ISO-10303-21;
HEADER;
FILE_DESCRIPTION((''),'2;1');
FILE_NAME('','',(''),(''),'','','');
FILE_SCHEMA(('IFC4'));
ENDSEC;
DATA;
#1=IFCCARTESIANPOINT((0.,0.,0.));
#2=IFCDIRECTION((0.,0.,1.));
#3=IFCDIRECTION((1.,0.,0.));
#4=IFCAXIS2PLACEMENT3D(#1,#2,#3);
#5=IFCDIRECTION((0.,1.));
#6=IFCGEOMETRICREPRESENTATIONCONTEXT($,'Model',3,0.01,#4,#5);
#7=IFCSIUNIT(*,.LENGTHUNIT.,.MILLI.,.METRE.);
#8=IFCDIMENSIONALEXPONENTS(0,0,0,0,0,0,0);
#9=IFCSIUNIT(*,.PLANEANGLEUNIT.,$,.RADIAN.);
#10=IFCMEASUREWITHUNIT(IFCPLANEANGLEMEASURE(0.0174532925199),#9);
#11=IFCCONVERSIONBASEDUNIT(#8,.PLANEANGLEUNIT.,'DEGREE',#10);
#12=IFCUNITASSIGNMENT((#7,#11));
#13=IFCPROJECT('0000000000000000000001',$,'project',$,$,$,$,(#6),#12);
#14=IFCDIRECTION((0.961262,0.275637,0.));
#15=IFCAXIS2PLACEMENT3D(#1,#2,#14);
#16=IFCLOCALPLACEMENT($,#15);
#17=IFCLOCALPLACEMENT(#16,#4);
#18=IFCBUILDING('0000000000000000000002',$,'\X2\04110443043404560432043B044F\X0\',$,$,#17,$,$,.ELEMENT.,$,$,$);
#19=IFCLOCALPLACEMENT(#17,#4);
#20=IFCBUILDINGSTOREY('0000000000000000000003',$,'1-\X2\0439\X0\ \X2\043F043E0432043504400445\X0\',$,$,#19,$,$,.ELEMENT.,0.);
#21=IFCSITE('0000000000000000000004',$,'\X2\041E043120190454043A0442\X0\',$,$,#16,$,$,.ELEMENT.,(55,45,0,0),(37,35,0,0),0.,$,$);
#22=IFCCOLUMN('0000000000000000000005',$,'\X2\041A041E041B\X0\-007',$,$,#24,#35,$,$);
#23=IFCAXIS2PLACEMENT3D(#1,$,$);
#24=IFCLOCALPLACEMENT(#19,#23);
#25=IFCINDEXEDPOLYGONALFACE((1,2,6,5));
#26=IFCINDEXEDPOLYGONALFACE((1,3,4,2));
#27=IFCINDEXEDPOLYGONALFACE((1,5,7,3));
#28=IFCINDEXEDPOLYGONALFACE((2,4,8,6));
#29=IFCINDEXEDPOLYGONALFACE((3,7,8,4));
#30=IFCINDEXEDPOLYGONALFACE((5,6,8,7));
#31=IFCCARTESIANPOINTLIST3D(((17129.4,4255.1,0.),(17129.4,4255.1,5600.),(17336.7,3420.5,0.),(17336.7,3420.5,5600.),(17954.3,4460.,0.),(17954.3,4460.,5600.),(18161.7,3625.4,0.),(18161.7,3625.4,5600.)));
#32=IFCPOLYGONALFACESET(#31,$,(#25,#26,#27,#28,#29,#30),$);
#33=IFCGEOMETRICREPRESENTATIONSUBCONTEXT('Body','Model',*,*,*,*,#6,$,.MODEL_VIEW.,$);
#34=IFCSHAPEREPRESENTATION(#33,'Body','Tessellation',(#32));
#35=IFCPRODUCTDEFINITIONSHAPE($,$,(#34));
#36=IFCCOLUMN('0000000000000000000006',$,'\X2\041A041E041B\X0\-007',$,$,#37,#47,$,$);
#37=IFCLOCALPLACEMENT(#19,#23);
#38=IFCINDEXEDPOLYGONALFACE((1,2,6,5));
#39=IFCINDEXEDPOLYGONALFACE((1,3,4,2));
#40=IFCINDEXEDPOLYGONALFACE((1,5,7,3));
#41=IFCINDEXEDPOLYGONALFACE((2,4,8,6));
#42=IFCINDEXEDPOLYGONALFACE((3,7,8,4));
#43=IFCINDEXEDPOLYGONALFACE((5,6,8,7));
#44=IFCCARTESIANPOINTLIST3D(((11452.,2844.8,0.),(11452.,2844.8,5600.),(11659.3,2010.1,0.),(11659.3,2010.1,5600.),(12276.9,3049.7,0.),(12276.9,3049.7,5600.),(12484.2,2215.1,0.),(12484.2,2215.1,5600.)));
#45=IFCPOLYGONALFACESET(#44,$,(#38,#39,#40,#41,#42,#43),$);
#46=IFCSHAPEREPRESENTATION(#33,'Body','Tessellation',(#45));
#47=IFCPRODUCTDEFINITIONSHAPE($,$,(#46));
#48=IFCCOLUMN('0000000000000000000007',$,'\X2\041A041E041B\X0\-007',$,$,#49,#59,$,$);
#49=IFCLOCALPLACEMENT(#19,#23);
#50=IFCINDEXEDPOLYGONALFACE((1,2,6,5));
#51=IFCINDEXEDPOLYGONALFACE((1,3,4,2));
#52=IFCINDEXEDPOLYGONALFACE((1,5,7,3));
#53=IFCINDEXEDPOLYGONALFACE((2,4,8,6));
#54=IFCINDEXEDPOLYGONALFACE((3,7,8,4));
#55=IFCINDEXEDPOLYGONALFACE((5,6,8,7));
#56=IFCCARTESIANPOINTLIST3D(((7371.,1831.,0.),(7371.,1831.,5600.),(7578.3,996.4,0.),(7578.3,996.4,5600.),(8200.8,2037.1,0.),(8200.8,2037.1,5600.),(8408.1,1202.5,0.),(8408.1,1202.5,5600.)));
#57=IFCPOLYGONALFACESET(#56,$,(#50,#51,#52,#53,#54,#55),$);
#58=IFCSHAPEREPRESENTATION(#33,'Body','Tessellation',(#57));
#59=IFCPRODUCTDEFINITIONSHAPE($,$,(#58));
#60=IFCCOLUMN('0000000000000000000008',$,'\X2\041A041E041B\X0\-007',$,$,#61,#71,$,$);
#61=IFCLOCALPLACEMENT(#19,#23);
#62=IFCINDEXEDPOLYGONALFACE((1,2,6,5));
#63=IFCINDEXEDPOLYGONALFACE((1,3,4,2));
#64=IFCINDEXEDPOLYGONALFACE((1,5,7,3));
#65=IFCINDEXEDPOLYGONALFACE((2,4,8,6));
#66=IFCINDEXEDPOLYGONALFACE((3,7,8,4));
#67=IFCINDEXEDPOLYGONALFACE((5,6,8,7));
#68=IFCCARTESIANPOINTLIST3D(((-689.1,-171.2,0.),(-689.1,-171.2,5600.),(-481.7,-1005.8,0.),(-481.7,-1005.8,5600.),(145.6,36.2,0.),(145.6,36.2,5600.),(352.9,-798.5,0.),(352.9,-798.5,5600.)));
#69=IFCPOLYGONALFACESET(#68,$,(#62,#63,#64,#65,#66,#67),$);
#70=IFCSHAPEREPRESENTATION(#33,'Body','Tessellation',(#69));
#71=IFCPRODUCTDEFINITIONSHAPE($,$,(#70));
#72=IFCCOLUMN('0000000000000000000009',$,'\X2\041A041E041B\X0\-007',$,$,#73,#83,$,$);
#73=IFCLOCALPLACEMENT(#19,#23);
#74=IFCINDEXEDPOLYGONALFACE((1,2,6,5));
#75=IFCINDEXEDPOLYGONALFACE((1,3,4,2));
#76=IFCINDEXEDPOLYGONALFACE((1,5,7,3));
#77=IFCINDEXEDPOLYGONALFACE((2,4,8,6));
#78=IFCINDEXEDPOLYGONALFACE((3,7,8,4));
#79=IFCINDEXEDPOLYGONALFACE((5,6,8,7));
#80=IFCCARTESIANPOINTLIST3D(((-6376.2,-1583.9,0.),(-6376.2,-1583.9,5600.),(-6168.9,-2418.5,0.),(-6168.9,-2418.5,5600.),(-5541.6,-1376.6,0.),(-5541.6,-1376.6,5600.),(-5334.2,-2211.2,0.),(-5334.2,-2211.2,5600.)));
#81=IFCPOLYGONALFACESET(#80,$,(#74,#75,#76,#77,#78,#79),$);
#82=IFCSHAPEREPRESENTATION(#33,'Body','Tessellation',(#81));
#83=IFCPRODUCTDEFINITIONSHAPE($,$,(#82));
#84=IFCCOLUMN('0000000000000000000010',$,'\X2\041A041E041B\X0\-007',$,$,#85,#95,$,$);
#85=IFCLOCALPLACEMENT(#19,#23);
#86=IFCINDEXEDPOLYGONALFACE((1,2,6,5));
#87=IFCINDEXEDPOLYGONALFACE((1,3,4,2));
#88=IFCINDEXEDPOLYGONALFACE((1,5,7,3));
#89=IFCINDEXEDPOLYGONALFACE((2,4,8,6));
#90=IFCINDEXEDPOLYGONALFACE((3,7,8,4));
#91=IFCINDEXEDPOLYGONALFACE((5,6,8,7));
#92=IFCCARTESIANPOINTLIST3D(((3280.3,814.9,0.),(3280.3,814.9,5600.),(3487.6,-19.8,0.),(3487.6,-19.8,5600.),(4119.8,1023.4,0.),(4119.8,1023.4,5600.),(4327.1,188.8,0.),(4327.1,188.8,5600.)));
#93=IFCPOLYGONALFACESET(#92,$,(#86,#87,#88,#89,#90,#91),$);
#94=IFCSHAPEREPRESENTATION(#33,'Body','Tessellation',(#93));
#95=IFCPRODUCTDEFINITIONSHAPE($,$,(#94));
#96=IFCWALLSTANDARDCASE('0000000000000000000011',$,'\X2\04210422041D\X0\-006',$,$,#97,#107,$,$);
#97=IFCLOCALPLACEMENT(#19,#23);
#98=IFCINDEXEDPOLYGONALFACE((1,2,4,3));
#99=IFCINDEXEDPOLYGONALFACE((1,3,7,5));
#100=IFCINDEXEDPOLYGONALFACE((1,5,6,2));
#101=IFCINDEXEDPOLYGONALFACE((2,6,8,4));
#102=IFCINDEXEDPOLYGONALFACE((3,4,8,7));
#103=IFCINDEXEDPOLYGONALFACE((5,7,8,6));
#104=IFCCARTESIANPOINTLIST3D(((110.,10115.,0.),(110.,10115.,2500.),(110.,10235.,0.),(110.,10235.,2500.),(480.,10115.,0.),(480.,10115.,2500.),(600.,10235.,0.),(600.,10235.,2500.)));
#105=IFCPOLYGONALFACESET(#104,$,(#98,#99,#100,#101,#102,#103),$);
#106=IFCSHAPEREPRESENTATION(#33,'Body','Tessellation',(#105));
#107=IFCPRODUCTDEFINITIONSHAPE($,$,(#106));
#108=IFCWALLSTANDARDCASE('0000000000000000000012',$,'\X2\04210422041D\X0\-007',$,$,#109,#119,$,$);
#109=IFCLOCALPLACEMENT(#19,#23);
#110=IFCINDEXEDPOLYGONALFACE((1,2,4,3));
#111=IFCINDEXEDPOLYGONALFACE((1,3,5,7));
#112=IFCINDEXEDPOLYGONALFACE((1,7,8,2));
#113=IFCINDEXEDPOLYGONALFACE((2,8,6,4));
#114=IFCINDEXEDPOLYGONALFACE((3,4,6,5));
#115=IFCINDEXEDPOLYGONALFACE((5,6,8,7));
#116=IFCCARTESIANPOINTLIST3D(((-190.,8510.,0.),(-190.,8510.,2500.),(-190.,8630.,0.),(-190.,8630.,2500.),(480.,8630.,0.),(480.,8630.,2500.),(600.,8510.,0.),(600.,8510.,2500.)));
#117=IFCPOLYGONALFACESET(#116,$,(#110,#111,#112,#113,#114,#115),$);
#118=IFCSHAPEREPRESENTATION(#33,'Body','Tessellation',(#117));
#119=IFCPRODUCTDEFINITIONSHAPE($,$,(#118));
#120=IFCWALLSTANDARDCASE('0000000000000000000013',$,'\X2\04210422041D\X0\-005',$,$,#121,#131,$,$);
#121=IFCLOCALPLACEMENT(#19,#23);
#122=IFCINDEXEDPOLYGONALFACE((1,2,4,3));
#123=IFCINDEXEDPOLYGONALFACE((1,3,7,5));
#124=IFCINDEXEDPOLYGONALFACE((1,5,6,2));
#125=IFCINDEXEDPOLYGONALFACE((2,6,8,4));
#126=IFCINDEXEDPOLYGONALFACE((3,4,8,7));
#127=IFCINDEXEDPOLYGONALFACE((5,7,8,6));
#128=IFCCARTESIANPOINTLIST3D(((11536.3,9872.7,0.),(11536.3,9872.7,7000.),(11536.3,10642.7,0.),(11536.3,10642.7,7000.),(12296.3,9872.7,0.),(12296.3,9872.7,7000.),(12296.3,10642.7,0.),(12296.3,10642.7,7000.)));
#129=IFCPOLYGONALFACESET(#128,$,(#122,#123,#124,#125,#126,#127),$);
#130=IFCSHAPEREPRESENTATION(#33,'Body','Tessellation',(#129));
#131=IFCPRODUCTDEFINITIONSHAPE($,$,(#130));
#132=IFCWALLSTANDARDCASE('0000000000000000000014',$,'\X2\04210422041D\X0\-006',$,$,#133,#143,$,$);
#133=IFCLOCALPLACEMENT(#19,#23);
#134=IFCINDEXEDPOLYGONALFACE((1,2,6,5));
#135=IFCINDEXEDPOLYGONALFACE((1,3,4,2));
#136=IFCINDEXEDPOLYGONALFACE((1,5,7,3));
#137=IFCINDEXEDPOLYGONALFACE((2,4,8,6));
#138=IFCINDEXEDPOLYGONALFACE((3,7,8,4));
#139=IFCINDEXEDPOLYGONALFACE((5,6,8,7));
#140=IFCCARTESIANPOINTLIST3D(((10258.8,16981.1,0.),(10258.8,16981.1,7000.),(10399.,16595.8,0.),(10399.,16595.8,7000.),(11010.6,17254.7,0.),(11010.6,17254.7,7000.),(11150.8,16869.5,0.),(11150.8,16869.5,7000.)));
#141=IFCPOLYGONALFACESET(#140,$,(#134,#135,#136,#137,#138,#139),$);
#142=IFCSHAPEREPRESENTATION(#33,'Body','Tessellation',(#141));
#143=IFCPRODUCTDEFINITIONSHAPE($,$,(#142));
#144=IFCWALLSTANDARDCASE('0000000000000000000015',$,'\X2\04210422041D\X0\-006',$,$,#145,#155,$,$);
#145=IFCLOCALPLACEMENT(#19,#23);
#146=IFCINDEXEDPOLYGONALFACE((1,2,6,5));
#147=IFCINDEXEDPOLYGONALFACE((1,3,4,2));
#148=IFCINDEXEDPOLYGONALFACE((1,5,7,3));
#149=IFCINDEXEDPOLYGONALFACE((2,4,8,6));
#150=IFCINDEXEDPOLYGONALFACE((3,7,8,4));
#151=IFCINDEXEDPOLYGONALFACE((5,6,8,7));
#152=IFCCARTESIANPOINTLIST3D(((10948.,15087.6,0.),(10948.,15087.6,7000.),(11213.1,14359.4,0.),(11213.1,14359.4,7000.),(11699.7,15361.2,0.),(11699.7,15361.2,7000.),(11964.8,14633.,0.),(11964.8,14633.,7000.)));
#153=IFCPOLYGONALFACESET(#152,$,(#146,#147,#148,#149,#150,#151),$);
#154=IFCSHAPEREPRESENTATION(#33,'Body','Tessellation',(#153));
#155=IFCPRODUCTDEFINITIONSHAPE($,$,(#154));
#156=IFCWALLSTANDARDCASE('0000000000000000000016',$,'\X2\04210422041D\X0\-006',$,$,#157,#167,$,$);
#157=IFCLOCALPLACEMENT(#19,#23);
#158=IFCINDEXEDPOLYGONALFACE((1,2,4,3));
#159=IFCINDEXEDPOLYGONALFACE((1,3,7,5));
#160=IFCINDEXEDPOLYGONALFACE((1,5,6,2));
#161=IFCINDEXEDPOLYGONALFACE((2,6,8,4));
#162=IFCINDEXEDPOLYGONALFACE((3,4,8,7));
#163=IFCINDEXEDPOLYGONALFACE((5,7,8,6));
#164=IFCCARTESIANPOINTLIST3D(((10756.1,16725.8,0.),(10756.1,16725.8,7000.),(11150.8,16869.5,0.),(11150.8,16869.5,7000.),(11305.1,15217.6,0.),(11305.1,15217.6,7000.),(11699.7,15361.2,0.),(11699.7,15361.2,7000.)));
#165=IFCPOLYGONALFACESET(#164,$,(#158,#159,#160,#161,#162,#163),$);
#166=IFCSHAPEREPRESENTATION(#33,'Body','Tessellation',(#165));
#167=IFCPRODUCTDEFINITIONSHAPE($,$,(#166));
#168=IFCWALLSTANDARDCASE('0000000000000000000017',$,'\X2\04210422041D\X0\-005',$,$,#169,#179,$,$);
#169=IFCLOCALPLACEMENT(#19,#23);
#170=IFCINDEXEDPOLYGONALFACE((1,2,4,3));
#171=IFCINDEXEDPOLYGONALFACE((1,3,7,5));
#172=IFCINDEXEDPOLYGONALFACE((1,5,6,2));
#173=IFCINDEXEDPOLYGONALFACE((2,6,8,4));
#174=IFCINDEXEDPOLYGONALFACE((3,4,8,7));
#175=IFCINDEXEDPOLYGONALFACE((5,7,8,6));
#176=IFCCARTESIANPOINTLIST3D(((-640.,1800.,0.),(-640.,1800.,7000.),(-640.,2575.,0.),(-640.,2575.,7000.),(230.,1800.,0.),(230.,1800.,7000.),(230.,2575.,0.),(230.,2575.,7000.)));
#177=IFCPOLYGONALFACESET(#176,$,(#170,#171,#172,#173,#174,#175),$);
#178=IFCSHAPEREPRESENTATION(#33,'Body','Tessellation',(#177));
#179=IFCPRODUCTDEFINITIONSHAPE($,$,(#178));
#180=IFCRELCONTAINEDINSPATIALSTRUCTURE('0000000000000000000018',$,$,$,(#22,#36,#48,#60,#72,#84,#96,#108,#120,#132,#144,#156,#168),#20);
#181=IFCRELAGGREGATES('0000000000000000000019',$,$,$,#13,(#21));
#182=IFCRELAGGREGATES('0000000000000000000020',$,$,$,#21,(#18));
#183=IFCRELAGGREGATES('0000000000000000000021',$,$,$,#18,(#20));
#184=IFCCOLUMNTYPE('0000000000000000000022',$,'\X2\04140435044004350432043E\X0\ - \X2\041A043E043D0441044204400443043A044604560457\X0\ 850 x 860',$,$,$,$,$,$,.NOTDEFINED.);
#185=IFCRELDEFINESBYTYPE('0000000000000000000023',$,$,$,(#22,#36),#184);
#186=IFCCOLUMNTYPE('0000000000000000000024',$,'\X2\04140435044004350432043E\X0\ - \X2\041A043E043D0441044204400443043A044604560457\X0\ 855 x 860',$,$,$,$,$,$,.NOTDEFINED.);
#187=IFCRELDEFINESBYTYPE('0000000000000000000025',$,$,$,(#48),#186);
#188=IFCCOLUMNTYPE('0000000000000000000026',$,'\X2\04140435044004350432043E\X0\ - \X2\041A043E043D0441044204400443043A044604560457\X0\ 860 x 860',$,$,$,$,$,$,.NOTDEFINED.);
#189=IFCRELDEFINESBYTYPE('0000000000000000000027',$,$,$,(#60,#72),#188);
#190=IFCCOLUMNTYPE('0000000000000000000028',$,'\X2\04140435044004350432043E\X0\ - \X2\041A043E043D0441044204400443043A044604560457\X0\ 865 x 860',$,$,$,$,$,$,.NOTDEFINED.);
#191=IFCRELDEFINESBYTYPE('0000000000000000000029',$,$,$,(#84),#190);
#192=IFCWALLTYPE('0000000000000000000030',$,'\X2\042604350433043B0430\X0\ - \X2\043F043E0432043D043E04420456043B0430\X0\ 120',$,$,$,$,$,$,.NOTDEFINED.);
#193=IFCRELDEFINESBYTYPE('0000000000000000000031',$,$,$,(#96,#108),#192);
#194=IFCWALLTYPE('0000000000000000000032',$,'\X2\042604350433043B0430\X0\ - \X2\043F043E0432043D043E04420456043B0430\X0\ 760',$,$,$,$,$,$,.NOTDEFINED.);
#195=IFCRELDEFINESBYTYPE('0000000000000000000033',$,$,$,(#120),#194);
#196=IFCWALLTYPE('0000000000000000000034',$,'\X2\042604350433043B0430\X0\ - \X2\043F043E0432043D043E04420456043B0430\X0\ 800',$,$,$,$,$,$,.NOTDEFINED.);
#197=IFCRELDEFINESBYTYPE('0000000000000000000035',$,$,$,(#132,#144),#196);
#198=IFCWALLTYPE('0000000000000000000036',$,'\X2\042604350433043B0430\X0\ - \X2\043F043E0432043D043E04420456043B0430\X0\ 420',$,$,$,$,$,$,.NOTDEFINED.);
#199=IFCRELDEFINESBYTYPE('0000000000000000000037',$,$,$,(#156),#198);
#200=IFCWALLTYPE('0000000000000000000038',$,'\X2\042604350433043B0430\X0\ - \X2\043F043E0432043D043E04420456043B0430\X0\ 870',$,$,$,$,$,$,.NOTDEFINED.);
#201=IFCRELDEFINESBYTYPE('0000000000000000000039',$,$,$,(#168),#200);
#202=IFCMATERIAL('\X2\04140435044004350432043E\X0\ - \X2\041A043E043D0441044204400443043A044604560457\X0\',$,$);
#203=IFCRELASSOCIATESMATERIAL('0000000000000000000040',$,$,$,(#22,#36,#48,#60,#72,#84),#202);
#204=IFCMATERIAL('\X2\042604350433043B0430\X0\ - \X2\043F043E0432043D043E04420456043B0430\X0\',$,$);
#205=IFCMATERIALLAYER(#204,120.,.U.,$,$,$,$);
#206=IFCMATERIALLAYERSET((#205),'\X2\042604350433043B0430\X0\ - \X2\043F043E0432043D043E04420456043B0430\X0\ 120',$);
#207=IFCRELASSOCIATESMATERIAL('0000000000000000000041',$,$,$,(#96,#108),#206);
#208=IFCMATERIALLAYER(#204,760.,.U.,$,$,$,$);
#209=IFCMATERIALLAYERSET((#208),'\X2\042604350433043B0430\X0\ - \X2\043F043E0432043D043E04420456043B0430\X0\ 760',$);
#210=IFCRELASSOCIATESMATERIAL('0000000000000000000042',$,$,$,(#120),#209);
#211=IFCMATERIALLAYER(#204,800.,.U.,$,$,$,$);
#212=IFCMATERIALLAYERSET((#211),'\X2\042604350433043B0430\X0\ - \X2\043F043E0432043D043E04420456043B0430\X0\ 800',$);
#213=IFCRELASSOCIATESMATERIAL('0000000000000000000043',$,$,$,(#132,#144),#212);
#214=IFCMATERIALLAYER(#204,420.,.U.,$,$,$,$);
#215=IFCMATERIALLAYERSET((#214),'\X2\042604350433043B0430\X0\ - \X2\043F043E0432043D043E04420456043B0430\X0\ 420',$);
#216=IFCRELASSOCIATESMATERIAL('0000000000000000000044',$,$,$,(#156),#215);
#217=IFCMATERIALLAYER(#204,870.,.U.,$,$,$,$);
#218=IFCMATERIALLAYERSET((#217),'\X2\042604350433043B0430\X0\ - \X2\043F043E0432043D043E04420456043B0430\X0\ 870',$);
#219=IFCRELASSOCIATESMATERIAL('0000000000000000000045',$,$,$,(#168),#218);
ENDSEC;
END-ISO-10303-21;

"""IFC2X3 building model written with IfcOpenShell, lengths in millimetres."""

from ifc_helpers import new_model, entity, si_unit, converted_unit, direction, frame, origin_with_axes, origin_2d_with_axis, place, context, subcontext, project, spatial, polyline, rectangle, outline, extrude, material, layer, layer_set, layer_usage, type_object, element, save


model = new_model("IFC2X3")

# Units and contexts
model_context = context("Model", 3, precision=0.01, world=origin_with_axes(), true_north=direction((0.0, 1.0)))
body_context = subcontext(model_context, "Body", "Model", "MODEL_VIEW")
ifc_project = project(units=[si_unit("LENGTHUNIT", "METRE", prefix="MILLI"), converted_unit("PLANEANGLEUNIT", "DEGREE", entity("IfcPlaneAngleMeasure", 0.0174532925199), si_unit("PLANEANGLEUNIT", "RADIAN"), dimensions=[0, 0, 0, 0, 0, 0, 0])], contexts=[model_context])

# Site, building, storey
site_placement = place(None, frame((0.0, 0.0, 0.0), z_axis=(0.0, 0.0, 1.0), x_axis=(0.961262, 0.275637, 0.0)))
site = spatial("IfcSite", under=ifc_project, at=site_placement, Name="Об’єкт", CompositionType="ELEMENT", RefLatitude=(55, 45, 0, 0), RefLongitude=(37, 35, 0, 0), RefElevation=0.0)
building_placement = place(site_placement, origin_with_axes())
building = spatial("IfcBuilding", under=site, at=building_placement, Name="Будівля", CompositionType="ELEMENT")
storey_placement = place(building_placement, origin_with_axes())
storey = spatial("IfcBuildingStorey", under=building, at=storey_placement, Name="1-й поверх", CompositionType="ELEMENT", Elevation=0.0)

# Columns
ifc_material_1 = material(Name="Дерево - Конструкції")
column_type_1 = type_object("IfcColumnType", Name="Дерево - Конструкції 850 x 860", PredefinedType="NOTDEFINED")
for number, where, z_axis, x_axis, name in (
    (1, (17645.5, 3940.3, 0.0), (0.0, 0.0, 1.0), (0.970505, 0.241083, 0.0), "КОЛ-007"),
    (2, (11968.1, 2529.9, 0.0), (0.0, 0.0, 1.0), (0.970505, 0.241083, 0.0), "КОЛ-007"),
):
    element("IfcColumn", number, at=place(storey_placement, frame(where, z_axis=z_axis, x_axis=x_axis)), inside=storey, type_object=column_type_1, material=ifc_material_1, Name=name, context=body_context, shape_type="SweptSolid", body=[
        extrude(rectangle(XDim=850.0, YDim=860.0, at=origin_2d_with_axis()), origin_with_axes(), (0.0, 0.0, 1.0), 5600.0),
    ])
column_type_2 = type_object("IfcColumnType", Name="Дерево - Конструкції 855 x 860", PredefinedType="NOTDEFINED")
column_1_placement = place(storey_placement, frame((7889.5, 1516.8, 0.0), z_axis=(0.0, 0.0, 1.0), x_axis=(0.970505, 0.241083, 0.0)))
element("IfcColumn", 3, at=column_1_placement, inside=storey, type_object=column_type_2, material=ifc_material_1, Name="КОЛ-007", context=body_context, shape_type="SweptSolid", body=[
    extrude(rectangle(XDim=855.0, YDim=860.0, at=origin_2d_with_axis()), origin_with_axes(), (0.0, 0.0, 1.0), 5600.0),
])
column_type_3 = type_object("IfcColumnType", Name="Дерево - Конструкції 860 x 860", PredefinedType="NOTDEFINED")
for number, where, z_axis, x_axis, name in (
    (4, (-168.1, -484.8, 0.0), (0.0, 0.0, 1.0), (0.970505, 0.241083, 0.0), "КОЛ-007"),
    (5, (-5855.2, -1897.6, 0.0), (0.0, 0.0, 1.0), (0.970505, 0.241083, 0.0), "КОЛ-007"),
):
    element("IfcColumn", number, at=place(storey_placement, frame(where, z_axis=z_axis, x_axis=x_axis)), inside=storey, type_object=column_type_3, material=ifc_material_1, Name=name, context=body_context, shape_type="SweptSolid", body=[
        extrude(rectangle(XDim=860.0, YDim=860.0, at=origin_2d_with_axis()), origin_with_axes(), (0.0, 0.0, 1.0), 5600.0),
    ])
column_type_4 = type_object("IfcColumnType", Name="Дерево - Конструкції 865 x 860", PredefinedType="NOTDEFINED")
column_2_placement = place(storey_placement, frame((3803.7, 501.8, 0.0), z_axis=(0.0, 0.0, 1.0), x_axis=(0.970505, 0.241083, 0.0)))
element("IfcColumn", 6, at=column_2_placement, inside=storey, type_object=column_type_4, material=ifc_material_1, Name="КОЛ-007", context=body_context, shape_type="SweptSolid", body=[
    extrude(rectangle(XDim=865.0, YDim=860.0, at=origin_2d_with_axis()), origin_with_axes(), (0.0, 0.0, 1.0), 5600.0),
])

# Walls
ifc_material_2 = material(Name="Цегла - повнотіла")
ifc_layer_1 = layer(ifc_material_2, 120.0, ventilated="UNKNOWN")
ifc_layer_set_1 = layer_set([ifc_layer_1], Name="Цегла - повнотіла 120")
ifc_layer_usage_1 = layer_usage(ifc_layer_set_1, "AXIS2", "POSITIVE", 0.0)
wall_type_1 = type_object("IfcWallType", Name="Цегла - повнотіла 120", PredefinedType="NOTDEFINED")
wall_1_placement = place(storey_placement, frame((600.0, 10235.0, 0.0), z_axis=(0.0, 0.0, 1.0), x_axis=(-1.0, 0.0, 0.0)))
element("IfcWallStandardCase", 7, at=wall_1_placement, inside=storey, type_object=wall_type_1, material=ifc_layer_usage_1, Name="СТН-006", context=body_context, shape_type="SweptSolid", body=[
    extrude(outline(polyline([(0.0, 0.0), (490.0, 0.0), (490.0, 120.0), (120.0, 120.0), (0.0, 0.0)])), origin_with_axes(), (0.0, 0.0, 1.0), 2500.0),
])
ifc_layer_usage_2 = layer_usage(ifc_layer_set_1, "AXIS2", "POSITIVE", -120.0)
wall_2_placement = place(storey_placement, frame((600.0, 8510.0, 0.0), z_axis=(0.0, 0.0, 1.0), x_axis=(-1.0, 0.0, 0.0)))
element("IfcWallStandardCase", 8, at=wall_2_placement, inside=storey, type_object=wall_type_1, material=ifc_layer_usage_2, Name="СТН-007", context=body_context, shape_type="SweptSolid", body=[
    extrude(outline(polyline([(120.0, -120.0), (790.0, -120.0), (790.0, 0.0), (0.0, 0.0), (120.0, -120.0)])), origin_with_axes(), (0.0, 0.0, 1.0), 2500.0),
])
ifc_layer_2 = layer(ifc_material_2, 760.0, ventilated="UNKNOWN")
ifc_layer_set_2 = layer_set([ifc_layer_2], Name="Цегла - повнотіла 760")
ifc_layer_usage_3 = layer_usage(ifc_layer_set_2, "AXIS2", "POSITIVE", 0.0)
wall_type_2 = type_object("IfcWallType", Name="Цегла - повнотіла 760", PredefinedType="NOTDEFINED")
wall_3_placement = place(storey_placement, frame((12296.3, 9872.7, 0.0), z_axis=(0.0, 0.0, 1.0), x_axis=(0.0, 1.0, 0.0)))
element("IfcWallStandardCase", 9, at=wall_3_placement, inside=storey, type_object=wall_type_2, material=ifc_layer_usage_3, Name="СТН-005", context=body_context, shape_type="SweptSolid", body=[
    extrude(outline(polyline([(0.0, 0.0), (770.0, 0.0), (770.0, 760.0), (0.0, 760.0), (0.0, 0.0)])), origin_with_axes(), (0.0, 0.0, 1.0), 7000.0),
])
ifc_layer_3 = layer(ifc_material_2, 800.0, ventilated="UNKNOWN")
ifc_layer_set_3 = layer_set([ifc_layer_3], Name="Цегла - повнотіла 800")
ifc_layer_usage_4 = layer_usage(ifc_layer_set_3, "AXIS2", "POSITIVE", 0.0)
wall_type_3 = type_object("IfcWallType", Name="Цегла - повнотіла 800", PredefinedType="NOTDEFINED")
wall_4_placement = place(storey_placement, frame((11150.8, 16869.5, 0.0), z_axis=(0.0, 0.0, 1.0), x_axis=(-0.34202, 0.939693, 0.0)))
element("IfcWallStandardCase", 10, at=wall_4_placement, inside=storey, type_object=wall_type_3, material=ifc_layer_usage_4, Name="СТН-006", context=body_context, shape_type="SweptSolid", body=[
    extrude(outline(polyline([(0.0, 0.0), (410.0, 0.0), (410.0, 800.0), (0.0, 800.0), (0.0, 0.0)])), origin_with_axes(), (0.0, 0.0, 1.0), 7000.0),
])
ifc_layer_usage_5 = layer_usage(ifc_layer_set_3, "AXIS2", "POSITIVE", 0.0)
wall_5_placement = place(storey_placement, frame((11964.8, 14633.0, 0.0), z_axis=(0.0, 0.0, 1.0), x_axis=(-0.34202, 0.939693, 0.0)))
element("IfcWallStandardCase", 11, at=wall_5_placement, inside=storey, type_object=wall_type_3, material=ifc_layer_usage_5, Name="СТН-006", context=body_context, shape_type="SweptSolid", body=[
    extrude(outline(polyline([(0.0, 0.0), (775.0, 0.0), (775.0, 800.0), (0.0, 800.0), (0.0, 0.0)])), origin_with_axes(), (0.0, 0.0, 1.0), 7000.0),
])
ifc_layer_4 = layer(ifc_material_2, 420.0, ventilated="UNKNOWN")
ifc_layer_set_4 = layer_set([ifc_layer_4], Name="Цегла - повнотіла 420")
ifc_layer_usage_6 = layer_usage(ifc_layer_set_4, "AXIS2", "POSITIVE", 0.0)
wall_type_4 = type_object("IfcWallType", Name="Цегла - повнотіла 420", PredefinedType="NOTDEFINED")
wall_6_placement = place(storey_placement, frame((11699.7, 15361.2, 0.0), z_axis=(0.0, 0.0, 1.0), x_axis=(-0.34202, 0.939693, 0.0)))
element("IfcWallStandardCase", 12, at=wall_6_placement, inside=storey, type_object=wall_type_4, material=ifc_layer_usage_6, Name="СТН-006", context=body_context, shape_type="SweptSolid", body=[
    extrude(outline(polyline([(0.0, 0.0), (1605.0, 0.0), (1605.0, 420.0), (0.0, 420.0), (0.0, 0.0)])), origin_with_axes(), (0.0, 0.0, 1.0), 7000.0),
])
ifc_layer_5 = layer(ifc_material_2, 870.0, ventilated="UNKNOWN")
ifc_layer_set_5 = layer_set([ifc_layer_5], Name="Цегла - повнотіла 870")
ifc_layer_usage_7 = layer_usage(ifc_layer_set_5, "AXIS2", "POSITIVE", -870.0)
wall_type_5 = type_object("IfcWallType", Name="Цегла - повнотіла 870", PredefinedType="NOTDEFINED")
wall_7_placement = place(storey_placement, frame((-640.0, 1800.0, 0.0), z_axis=(0.0, 0.0, 1.0), x_axis=(0.0, 1.0, 0.0)))
element("IfcWallStandardCase", 13, at=wall_7_placement, inside=storey, type_object=wall_type_5, material=ifc_layer_usage_7, Name="СТН-005", context=body_context, shape_type="SweptSolid", body=[
    extrude(outline(polyline([(0.0, -870.0), (775.0, -870.0), (775.0, 0.0), (0.0, 0.0), (0.0, -870.0)])), origin_with_axes(), (0.0, 0.0, 1.0), 7000.0),
])

save(model, "model.ifc")
